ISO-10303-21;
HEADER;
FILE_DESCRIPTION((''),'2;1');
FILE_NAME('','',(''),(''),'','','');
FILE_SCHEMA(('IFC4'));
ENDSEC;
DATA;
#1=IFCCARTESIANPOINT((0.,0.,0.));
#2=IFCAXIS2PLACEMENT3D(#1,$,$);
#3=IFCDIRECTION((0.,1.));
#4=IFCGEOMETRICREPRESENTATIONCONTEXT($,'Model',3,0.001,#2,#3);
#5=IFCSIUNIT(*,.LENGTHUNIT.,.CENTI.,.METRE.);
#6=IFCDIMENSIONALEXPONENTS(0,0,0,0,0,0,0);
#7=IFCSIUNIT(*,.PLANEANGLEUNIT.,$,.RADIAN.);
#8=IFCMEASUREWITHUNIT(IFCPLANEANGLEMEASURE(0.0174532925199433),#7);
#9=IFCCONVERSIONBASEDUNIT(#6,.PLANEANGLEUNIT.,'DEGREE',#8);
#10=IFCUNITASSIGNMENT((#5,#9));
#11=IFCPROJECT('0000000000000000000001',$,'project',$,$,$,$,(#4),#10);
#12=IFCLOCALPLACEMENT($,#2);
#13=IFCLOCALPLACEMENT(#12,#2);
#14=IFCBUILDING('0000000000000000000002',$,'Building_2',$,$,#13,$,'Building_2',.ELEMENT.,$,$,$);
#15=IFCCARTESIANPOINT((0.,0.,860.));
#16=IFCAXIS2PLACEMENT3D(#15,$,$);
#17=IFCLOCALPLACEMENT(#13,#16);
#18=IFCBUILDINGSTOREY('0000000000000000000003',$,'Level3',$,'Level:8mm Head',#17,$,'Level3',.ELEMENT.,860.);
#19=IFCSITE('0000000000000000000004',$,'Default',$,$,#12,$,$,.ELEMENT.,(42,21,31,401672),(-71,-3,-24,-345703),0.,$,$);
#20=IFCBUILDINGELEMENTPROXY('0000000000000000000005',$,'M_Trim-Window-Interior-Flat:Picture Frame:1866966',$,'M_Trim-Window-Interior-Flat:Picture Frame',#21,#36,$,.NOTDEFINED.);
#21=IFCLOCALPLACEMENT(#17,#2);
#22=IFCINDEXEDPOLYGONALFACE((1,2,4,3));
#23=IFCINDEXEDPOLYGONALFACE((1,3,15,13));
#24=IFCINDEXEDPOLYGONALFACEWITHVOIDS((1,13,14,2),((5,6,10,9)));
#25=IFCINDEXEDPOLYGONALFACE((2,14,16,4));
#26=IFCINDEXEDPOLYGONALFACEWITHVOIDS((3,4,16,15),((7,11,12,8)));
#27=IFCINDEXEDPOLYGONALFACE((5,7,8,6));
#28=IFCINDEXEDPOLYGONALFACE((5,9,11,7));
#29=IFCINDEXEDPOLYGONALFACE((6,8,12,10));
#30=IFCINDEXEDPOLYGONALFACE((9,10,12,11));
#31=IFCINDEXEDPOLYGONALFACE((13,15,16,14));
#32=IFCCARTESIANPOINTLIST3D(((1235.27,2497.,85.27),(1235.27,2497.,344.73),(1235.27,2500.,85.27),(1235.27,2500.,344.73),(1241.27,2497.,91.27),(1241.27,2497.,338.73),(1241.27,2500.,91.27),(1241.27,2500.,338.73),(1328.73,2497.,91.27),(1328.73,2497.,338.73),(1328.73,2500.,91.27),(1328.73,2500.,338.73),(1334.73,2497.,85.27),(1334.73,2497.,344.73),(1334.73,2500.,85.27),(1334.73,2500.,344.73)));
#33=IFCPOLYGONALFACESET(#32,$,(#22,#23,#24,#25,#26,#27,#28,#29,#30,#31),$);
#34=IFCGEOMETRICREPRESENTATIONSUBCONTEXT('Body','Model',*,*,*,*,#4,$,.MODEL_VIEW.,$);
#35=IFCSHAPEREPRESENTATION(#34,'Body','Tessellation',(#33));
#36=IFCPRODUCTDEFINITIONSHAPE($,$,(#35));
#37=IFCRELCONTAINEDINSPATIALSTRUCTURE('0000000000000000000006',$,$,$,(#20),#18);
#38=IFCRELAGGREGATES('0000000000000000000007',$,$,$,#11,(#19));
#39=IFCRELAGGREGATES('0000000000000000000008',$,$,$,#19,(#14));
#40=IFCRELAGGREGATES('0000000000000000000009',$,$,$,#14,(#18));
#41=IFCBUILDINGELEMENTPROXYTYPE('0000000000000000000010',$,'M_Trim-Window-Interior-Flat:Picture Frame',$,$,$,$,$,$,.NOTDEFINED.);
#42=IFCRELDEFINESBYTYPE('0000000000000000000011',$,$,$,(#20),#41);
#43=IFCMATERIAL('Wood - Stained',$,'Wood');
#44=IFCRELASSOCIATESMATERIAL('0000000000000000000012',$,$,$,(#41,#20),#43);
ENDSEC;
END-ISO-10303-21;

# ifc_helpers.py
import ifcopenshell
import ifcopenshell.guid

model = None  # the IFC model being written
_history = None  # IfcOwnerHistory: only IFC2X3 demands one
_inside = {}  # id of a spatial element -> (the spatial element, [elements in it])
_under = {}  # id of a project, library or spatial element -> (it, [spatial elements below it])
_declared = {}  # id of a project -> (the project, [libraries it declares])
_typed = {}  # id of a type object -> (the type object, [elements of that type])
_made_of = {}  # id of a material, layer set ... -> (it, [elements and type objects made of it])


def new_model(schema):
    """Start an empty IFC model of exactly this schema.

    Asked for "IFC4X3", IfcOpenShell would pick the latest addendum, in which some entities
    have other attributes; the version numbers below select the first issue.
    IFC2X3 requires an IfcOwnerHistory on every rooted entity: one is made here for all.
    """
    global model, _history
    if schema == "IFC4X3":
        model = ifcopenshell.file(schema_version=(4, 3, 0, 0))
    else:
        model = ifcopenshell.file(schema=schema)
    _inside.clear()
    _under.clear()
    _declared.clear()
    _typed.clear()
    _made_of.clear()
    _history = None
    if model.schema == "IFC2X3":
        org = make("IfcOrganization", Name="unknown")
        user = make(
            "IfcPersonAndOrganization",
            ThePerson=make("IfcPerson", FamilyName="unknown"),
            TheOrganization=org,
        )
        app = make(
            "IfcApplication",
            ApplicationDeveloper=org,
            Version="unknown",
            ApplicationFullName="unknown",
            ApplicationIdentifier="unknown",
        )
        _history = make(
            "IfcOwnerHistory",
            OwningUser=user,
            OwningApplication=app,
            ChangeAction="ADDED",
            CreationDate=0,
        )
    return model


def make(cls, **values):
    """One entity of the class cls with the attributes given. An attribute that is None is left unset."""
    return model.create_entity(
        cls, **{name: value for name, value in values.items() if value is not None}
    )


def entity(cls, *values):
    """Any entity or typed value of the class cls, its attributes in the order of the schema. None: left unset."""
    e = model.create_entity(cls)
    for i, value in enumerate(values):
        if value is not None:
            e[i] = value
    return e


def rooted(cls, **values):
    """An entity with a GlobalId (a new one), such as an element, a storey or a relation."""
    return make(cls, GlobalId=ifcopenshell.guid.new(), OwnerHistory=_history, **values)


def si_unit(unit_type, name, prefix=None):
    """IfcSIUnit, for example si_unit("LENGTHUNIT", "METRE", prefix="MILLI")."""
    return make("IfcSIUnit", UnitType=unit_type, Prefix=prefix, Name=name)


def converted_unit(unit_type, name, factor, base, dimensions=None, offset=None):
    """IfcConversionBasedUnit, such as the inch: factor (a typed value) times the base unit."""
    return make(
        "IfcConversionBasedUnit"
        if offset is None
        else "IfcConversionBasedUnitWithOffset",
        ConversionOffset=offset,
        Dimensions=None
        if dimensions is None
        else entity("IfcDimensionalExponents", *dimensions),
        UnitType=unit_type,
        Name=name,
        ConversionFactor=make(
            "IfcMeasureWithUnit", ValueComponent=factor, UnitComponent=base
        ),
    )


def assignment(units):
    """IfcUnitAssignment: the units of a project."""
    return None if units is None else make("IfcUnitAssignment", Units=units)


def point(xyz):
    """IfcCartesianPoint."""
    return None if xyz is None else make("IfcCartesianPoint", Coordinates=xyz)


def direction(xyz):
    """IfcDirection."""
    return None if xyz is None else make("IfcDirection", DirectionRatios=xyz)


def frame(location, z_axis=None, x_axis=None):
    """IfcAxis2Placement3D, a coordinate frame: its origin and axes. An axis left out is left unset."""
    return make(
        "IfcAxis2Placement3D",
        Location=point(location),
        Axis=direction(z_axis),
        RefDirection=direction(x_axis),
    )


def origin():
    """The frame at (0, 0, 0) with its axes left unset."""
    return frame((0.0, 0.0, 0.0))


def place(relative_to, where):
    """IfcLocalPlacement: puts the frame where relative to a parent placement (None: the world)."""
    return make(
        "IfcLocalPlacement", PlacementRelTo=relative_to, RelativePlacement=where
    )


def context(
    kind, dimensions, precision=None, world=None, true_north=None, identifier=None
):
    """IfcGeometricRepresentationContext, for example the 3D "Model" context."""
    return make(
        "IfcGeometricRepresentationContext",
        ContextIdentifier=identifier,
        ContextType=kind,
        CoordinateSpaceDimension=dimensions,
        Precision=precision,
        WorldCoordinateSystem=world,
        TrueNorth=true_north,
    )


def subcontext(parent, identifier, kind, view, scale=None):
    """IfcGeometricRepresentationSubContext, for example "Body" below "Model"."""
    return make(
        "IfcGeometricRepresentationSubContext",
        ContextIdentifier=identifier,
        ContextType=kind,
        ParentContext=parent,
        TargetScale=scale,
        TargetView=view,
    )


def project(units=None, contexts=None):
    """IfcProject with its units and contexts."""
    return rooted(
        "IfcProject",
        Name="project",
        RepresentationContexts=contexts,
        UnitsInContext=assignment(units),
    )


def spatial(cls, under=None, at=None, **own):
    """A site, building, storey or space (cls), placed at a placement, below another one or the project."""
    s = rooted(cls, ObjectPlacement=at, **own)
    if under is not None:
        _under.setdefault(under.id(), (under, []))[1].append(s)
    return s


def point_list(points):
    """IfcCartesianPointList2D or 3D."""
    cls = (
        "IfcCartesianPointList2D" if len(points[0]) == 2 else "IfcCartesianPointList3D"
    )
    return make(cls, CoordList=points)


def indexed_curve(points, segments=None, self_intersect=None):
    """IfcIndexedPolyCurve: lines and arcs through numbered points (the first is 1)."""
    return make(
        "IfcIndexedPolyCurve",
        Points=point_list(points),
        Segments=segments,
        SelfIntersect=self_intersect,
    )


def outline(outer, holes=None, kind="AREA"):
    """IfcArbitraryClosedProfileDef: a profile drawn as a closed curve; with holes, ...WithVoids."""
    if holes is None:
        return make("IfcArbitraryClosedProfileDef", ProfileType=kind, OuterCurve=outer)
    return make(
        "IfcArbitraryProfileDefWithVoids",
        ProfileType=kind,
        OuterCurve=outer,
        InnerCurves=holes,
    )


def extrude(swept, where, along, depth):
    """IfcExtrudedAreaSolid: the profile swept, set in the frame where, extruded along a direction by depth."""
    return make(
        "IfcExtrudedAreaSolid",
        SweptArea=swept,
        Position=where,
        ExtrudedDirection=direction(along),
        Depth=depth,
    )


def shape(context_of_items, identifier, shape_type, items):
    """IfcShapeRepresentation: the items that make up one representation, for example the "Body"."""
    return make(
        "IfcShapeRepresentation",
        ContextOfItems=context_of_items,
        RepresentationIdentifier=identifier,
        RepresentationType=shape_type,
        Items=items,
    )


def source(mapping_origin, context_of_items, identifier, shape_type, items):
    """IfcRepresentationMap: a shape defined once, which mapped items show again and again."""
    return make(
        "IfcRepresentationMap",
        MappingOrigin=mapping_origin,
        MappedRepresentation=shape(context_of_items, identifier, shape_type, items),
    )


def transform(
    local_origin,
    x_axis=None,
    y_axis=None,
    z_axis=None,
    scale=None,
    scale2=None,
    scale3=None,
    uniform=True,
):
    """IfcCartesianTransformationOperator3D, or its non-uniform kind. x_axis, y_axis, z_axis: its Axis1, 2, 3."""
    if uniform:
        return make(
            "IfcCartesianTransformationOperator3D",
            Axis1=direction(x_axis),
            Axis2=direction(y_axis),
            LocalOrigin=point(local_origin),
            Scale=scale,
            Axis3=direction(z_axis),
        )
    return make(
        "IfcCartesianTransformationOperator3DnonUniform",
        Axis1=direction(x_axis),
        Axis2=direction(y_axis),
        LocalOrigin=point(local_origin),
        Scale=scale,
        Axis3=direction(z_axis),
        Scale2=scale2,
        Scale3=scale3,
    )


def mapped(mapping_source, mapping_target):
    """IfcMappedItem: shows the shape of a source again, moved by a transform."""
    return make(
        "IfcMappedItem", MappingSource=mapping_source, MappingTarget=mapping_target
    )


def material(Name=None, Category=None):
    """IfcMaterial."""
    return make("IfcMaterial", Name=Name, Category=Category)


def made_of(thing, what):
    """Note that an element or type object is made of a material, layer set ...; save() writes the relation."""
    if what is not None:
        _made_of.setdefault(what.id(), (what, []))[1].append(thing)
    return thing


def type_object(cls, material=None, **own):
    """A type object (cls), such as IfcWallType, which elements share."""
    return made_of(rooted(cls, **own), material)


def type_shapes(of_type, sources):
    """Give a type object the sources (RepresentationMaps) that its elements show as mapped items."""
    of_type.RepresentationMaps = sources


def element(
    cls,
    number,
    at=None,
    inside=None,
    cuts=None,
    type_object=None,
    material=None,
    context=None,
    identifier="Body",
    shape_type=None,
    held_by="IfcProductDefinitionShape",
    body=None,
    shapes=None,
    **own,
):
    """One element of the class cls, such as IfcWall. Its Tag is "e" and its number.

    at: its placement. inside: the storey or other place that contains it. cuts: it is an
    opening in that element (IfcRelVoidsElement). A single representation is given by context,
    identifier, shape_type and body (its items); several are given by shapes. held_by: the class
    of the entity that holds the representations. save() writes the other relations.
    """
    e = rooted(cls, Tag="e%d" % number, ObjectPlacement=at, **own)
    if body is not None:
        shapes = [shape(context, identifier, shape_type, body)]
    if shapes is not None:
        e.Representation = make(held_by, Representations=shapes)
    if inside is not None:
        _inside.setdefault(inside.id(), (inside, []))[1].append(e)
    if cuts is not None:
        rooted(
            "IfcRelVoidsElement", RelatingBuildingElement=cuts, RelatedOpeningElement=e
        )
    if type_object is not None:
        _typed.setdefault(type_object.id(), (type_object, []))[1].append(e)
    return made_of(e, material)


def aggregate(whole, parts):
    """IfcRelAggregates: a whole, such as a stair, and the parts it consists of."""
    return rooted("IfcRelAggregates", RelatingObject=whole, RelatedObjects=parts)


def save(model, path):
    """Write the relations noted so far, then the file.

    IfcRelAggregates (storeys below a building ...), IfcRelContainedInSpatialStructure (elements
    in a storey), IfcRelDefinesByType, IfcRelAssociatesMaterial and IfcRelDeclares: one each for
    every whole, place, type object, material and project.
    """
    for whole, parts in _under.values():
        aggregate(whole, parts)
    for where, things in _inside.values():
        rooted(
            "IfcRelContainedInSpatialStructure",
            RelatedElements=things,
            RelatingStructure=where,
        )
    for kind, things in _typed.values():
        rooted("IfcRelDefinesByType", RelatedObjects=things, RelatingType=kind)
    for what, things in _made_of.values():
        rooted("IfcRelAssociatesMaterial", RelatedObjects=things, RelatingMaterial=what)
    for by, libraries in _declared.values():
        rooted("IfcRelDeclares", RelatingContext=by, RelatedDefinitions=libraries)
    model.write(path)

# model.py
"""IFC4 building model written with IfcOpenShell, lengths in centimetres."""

from ifc_helpers import new_model, entity, si_unit, converted_unit, direction, frame, origin, place, context, subcontext, project, spatial, indexed_curve, outline, extrude, source, transform, mapped, material, type_object, type_shapes, element, save


model = new_model("IFC4")

# Units and contexts
model_context = context("Model", 3, precision=0.001, world=origin(), true_north=direction((0.0, 1.0)))
body_context = subcontext(model_context, "Body", "Model", "MODEL_VIEW")
ifc_project = project(units=[si_unit("LENGTHUNIT", "METRE", prefix="CENTI"), converted_unit("PLANEANGLEUNIT", "DEGREE", entity("IfcPlaneAngleMeasure", 0.0174532925199433), si_unit("PLANEANGLEUNIT", "RADIAN"), dimensions=[0, 0, 0, 0, 0, 0, 0])], contexts=[model_context])

# Site, building, storey
site_placement = place(None, origin())
site = spatial("IfcSite", under=ifc_project, at=site_placement, Name="Default", CompositionType="ELEMENT", RefLatitude=(42, 21, 31, 401672), RefLongitude=(-71, -3, -24, -345703), RefElevation=0.0)
building_placement = place(site_placement, origin())
building = spatial("IfcBuilding", under=site, at=building_placement, Name="Building_2", LongName="Building_2", CompositionType="ELEMENT")
storey_placement = place(building_placement, frame((0.0, 0.0, 860.0)))
storey = spatial("IfcBuildingStorey", under=building, at=storey_placement, Name="Level3", ObjectType="Level:8mm Head", LongName="Level3", CompositionType="ELEMENT", Elevation=860.0)

# Shared definitions
ifc_material_1 = material(Name="Wood - Stained", Category="Wood")

# Building element proxy
building_element_proxy_type_1 = type_object("IfcBuildingElementProxyType", Name="M_Trim-Window-Interior-Flat:Picture Frame", PredefinedType="NOTDEFINED", material=ifc_material_1)
shared_shape_1 = source(origin(), body_context, "Body", "SweptSolid", [
    extrude(outline(indexed_curve([(-49.73, -129.73), (49.73, -129.73), (49.73, 129.73), (-49.73, 129.73), (-49.73, -129.73)], self_intersect=False), holes=[indexed_curve([(-43.73, -123.73), (-43.73, 123.73), (43.73, 123.73), (43.73, -123.73), (-43.73, -123.73)], self_intersect=False)]), frame((0.0, -125.0, 0.0), z_axis=(0.0, 0.0, 1.0), x_axis=(-1.0, 0.0, 0.0)), (0.0, 0.0, 1.0), 3.0),
])
type_shapes(building_element_proxy_type_1, [shared_shape_1])
for number, where, z_axis, x_axis, name in (
    (1, (1285.0, 2500.0, 340.0), (0.0, -1.0, 0.0), (1.0, 0.0, 0.0), "M_Trim-Window-Interior-Flat:Picture Frame:1866966"),
):
    element("IfcBuildingElementProxy", number, at=place(storey_placement, frame(where, z_axis=z_axis, x_axis=x_axis)), inside=storey, type_object=building_element_proxy_type_1, material=ifc_material_1, Name=name, ObjectType="M_Trim-Window-Interior-Flat:Picture Frame", PredefinedType="NOTDEFINED", context=body_context, shape_type="MappedRepresentation", body=[
        mapped(shared_shape_1, transform((0.0, 0.0, 0.0), scale=1.0)),
    ])

save(model, "model.ifc")
